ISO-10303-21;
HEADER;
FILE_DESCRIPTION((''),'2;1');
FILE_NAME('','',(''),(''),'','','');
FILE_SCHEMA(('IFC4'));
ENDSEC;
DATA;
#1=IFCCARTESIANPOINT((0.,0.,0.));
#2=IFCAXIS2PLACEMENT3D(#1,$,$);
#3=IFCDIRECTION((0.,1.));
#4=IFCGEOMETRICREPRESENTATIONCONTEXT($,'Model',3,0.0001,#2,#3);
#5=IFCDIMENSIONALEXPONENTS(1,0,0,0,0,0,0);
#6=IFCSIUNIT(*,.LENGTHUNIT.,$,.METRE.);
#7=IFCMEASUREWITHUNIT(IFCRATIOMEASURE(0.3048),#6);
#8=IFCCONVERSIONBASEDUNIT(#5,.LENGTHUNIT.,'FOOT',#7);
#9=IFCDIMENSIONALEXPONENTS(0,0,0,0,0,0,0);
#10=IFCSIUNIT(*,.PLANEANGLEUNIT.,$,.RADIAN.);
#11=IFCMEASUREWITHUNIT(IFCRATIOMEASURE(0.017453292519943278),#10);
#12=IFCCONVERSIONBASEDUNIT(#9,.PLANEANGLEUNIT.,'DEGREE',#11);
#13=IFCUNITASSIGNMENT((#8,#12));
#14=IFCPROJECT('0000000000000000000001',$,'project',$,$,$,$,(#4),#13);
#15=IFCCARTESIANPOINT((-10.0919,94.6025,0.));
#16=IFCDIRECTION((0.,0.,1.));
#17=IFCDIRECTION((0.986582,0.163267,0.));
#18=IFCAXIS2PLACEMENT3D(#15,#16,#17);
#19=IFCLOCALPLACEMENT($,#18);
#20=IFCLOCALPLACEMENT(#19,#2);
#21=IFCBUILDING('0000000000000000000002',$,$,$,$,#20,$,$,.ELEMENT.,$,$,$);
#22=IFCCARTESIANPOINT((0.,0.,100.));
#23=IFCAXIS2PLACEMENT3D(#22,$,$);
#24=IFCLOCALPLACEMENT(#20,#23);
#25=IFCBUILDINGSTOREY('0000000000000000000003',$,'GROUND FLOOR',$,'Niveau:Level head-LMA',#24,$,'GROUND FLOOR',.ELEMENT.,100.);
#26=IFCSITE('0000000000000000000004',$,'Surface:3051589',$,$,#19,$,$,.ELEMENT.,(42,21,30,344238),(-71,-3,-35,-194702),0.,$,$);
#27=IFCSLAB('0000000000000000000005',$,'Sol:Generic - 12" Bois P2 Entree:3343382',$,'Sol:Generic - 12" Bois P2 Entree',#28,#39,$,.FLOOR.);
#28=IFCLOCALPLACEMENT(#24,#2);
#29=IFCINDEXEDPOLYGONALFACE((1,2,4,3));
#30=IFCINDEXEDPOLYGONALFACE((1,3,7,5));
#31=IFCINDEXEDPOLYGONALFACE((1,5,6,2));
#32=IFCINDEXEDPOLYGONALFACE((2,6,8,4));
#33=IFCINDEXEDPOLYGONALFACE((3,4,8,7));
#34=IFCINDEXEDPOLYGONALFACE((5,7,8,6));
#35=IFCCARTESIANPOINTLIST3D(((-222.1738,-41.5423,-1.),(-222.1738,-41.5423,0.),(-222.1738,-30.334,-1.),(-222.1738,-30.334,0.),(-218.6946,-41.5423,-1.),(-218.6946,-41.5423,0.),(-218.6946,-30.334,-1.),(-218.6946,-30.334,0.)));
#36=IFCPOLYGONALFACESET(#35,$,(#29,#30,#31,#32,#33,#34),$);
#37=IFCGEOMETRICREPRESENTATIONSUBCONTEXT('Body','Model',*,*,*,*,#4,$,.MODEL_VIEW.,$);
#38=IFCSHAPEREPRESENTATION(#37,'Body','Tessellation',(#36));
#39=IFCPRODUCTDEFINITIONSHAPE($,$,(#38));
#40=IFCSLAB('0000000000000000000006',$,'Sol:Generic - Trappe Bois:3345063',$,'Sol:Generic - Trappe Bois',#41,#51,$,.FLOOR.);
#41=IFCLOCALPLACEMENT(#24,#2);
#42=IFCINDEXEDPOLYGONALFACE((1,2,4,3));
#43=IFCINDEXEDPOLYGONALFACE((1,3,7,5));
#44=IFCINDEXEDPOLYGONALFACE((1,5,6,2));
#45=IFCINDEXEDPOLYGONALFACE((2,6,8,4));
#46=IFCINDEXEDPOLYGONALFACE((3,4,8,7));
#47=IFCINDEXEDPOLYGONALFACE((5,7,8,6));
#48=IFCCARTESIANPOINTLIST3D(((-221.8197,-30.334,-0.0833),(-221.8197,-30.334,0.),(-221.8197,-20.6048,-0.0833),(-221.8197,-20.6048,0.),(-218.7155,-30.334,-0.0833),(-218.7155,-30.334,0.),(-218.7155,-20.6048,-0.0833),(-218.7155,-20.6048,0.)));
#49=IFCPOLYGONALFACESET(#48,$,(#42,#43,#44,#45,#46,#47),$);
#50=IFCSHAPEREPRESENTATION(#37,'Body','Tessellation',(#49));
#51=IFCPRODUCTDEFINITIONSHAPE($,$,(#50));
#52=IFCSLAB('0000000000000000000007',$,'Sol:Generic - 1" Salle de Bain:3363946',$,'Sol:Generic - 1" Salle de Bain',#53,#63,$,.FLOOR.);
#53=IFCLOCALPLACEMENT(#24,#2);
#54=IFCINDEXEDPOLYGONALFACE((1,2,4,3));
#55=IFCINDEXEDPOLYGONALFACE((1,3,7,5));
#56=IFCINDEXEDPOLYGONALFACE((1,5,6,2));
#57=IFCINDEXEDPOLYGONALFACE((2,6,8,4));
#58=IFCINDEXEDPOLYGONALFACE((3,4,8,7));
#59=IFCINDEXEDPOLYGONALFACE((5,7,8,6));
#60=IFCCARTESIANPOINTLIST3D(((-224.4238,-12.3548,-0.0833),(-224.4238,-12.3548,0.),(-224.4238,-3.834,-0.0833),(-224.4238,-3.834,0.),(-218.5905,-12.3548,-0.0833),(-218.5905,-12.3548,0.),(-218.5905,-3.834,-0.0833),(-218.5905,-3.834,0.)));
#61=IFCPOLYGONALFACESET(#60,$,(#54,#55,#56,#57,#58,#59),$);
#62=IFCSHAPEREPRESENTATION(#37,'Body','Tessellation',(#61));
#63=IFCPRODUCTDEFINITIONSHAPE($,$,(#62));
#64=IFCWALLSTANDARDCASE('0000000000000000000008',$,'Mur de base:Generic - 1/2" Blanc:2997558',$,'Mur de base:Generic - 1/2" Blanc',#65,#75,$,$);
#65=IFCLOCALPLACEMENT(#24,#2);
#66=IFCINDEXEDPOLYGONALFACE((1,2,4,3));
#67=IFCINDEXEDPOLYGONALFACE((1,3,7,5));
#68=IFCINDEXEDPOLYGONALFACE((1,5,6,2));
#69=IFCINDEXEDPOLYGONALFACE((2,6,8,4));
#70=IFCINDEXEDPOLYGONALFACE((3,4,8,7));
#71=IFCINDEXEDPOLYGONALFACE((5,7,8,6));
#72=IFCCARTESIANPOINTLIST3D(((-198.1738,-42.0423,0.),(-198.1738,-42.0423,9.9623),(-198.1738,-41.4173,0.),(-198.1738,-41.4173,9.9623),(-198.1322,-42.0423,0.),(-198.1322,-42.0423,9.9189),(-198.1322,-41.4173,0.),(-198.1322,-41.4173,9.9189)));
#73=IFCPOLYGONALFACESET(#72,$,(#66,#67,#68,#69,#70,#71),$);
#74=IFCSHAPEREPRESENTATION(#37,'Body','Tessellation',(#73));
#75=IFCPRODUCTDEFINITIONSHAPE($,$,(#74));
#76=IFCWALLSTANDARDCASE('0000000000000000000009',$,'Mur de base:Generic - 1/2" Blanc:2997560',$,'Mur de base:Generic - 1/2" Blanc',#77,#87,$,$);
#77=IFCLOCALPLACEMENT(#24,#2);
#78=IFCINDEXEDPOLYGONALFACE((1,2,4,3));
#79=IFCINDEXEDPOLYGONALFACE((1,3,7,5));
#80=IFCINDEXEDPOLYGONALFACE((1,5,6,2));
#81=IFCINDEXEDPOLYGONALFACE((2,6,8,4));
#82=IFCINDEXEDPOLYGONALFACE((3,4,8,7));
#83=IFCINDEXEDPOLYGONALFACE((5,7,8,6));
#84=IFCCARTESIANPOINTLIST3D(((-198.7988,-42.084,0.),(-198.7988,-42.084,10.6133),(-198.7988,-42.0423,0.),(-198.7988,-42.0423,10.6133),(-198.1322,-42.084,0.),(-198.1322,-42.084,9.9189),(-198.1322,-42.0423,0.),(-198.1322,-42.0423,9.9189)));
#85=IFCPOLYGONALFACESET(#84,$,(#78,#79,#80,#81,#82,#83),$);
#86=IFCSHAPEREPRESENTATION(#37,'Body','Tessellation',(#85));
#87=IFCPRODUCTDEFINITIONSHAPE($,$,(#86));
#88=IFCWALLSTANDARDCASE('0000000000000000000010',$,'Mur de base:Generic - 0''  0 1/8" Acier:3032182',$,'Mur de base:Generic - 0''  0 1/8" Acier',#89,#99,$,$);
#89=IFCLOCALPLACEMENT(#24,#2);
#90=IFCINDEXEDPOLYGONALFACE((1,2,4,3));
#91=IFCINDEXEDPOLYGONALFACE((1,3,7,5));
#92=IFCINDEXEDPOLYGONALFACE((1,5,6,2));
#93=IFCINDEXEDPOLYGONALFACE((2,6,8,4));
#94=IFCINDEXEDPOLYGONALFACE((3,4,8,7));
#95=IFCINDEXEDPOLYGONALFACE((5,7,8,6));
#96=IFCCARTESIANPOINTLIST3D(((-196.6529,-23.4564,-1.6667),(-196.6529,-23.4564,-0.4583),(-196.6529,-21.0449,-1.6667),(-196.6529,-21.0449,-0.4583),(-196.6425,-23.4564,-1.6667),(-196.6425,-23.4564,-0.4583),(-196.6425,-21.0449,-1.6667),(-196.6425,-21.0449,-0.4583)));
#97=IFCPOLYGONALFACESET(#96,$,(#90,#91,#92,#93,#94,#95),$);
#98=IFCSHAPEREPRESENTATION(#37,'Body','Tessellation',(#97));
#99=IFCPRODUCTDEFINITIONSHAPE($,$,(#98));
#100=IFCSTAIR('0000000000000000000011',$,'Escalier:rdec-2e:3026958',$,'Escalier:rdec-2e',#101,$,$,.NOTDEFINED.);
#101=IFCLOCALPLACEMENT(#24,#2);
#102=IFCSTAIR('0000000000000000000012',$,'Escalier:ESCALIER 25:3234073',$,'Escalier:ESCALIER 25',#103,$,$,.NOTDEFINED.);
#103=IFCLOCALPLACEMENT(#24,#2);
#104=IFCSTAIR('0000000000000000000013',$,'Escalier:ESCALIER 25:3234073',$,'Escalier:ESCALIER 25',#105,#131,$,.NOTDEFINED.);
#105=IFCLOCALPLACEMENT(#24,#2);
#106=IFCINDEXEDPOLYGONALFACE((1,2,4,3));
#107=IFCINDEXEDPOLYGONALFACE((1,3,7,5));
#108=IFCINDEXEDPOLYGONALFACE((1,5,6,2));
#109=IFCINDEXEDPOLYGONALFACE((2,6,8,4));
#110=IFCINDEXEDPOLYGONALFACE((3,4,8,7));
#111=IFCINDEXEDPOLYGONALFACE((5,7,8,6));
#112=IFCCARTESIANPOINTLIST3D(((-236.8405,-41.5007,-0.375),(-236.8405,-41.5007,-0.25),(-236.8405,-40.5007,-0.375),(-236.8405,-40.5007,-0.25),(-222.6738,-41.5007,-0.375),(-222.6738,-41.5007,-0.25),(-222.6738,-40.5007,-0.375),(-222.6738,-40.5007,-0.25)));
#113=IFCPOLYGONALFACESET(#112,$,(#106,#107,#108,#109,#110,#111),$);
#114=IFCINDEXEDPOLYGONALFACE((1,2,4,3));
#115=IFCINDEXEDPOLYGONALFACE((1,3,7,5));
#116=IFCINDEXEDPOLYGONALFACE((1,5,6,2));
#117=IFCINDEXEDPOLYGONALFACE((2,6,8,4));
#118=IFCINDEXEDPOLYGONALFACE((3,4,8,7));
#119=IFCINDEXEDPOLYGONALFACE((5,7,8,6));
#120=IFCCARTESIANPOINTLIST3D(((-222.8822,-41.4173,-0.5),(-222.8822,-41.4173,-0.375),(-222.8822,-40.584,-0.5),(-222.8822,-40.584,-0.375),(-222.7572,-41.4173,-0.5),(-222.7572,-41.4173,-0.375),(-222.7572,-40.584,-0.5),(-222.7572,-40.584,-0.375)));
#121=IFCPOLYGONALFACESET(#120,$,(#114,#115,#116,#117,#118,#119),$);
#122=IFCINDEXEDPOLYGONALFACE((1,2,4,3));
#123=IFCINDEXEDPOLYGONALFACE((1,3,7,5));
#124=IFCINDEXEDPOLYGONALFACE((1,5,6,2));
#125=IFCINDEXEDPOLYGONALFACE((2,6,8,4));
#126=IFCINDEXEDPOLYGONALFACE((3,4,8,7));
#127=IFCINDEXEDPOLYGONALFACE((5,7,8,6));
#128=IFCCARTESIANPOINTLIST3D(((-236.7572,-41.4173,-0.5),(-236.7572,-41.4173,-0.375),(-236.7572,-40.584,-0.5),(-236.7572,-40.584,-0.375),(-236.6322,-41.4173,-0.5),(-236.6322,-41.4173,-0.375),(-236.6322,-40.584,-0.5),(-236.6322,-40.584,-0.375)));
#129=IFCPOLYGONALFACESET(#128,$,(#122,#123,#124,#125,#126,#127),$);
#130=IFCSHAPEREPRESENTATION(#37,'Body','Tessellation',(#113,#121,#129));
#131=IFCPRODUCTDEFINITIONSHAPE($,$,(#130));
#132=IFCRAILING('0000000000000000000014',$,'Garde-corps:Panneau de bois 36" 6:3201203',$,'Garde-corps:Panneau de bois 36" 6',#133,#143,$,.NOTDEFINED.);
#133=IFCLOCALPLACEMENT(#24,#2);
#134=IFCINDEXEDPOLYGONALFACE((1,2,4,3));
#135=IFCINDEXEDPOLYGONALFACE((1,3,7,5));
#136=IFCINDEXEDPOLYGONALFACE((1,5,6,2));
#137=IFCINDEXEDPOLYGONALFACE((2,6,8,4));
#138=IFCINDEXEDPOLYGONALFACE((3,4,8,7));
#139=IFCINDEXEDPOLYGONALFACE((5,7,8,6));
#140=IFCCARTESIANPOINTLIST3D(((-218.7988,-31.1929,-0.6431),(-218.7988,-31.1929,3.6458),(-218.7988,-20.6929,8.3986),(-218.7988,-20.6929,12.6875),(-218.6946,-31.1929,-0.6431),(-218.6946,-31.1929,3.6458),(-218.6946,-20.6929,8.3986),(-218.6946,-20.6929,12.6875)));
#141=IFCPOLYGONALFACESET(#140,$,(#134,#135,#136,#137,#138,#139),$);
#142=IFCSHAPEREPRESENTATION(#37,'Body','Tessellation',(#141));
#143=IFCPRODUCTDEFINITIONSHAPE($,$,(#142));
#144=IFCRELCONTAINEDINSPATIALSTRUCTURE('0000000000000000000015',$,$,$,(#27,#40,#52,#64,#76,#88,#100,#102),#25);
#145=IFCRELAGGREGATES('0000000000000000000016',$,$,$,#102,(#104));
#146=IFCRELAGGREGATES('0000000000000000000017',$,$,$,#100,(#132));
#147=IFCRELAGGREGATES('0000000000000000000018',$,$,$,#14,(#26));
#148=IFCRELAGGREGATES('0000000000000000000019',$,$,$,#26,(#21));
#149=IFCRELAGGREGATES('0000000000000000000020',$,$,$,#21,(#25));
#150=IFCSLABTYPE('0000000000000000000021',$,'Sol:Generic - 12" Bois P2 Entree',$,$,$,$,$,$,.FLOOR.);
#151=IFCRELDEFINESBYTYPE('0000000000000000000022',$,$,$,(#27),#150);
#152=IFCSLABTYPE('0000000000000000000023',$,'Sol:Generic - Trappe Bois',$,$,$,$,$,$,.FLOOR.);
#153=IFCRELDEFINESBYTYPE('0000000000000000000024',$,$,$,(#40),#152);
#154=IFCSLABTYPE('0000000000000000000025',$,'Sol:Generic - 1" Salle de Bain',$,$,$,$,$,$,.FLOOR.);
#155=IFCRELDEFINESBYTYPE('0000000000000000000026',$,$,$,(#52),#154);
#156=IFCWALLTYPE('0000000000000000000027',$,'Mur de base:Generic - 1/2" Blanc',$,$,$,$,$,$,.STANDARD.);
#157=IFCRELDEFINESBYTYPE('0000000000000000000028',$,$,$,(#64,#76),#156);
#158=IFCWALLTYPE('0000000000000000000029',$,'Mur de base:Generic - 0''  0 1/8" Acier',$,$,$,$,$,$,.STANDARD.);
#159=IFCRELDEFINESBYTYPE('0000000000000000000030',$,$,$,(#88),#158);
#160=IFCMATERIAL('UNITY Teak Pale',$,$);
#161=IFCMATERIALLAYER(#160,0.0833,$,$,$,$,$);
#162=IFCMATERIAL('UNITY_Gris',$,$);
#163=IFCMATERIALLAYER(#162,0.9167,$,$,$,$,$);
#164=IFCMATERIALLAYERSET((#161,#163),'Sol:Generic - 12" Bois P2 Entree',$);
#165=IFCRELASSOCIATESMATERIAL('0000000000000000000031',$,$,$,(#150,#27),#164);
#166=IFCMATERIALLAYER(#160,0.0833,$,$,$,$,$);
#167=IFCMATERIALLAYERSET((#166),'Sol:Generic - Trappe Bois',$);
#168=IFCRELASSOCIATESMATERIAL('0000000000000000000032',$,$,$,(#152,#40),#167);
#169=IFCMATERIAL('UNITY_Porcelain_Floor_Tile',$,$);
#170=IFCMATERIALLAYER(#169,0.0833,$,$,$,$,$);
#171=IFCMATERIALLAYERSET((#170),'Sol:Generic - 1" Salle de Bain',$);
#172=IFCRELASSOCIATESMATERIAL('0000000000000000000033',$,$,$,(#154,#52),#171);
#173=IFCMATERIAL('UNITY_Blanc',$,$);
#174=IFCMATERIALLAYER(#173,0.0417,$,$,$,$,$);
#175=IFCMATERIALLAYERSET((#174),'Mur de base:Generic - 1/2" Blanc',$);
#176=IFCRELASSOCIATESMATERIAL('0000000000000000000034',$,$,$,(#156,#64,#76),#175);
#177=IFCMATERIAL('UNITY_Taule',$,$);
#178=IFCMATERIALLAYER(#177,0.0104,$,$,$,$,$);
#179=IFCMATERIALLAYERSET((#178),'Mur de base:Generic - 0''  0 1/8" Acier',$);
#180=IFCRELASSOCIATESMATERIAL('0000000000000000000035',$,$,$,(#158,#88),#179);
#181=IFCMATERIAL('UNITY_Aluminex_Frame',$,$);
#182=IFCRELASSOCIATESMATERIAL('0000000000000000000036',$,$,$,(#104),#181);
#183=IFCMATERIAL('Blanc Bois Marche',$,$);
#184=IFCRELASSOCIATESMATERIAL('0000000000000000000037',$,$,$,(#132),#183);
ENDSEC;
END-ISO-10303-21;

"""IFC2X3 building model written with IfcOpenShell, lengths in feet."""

from ifc_helpers import new_model, entity, si_unit, converted_unit, direction, frame, frame_2d, origin, place, context, subcontext, project, spatial, polyline, rectangle, outline, extrude, clip, bounded_halfspace, material, layer, layer_set, layer_usage, type_object, element, aggregate, save


model = new_model("IFC2X3")

# Units and contexts
model_context = context("Model", 3, precision=0.0001, world=origin(), true_north=direction((0.0, 1.0)))
body_context = subcontext(model_context, "Body", "Model", "MODEL_VIEW")
ifc_project = project(units=[converted_unit("LENGTHUNIT", "FOOT", entity("IfcRatioMeasure", 0.3048), si_unit("LENGTHUNIT", "METRE"), dimensions=[1, 0, 0, 0, 0, 0, 0]), converted_unit("PLANEANGLEUNIT", "DEGREE", entity("IfcRatioMeasure", 0.017453292519943278), si_unit("PLANEANGLEUNIT", "RADIAN"), dimensions=[0, 0, 0, 0, 0, 0, 0])], contexts=[model_context])

# Site, building, storey
site_placement = place(None, frame((-10.0919, 94.6025, 0.0), z_axis=(0.0, 0.0, 1.0), x_axis=(0.986582, 0.163267, 0.0)))
site = spatial("IfcSite", under=ifc_project, at=site_placement, Name="Surface:3051589", CompositionType="ELEMENT", RefLatitude=(42, 21, 30, 344238), RefLongitude=(-71, -3, -35, -194702), RefElevation=0.0)
building_placement = place(site_placement, origin())
building = spatial("IfcBuilding", under=site, at=building_placement, CompositionType="ELEMENT")
storey_placement = place(building_placement, frame((0.0, 0.0, 100.0)))
storey = spatial("IfcBuildingStorey", under=building, at=storey_placement, Name="GROUND FLOOR", ObjectType="Niveau:Level head-LMA", LongName="GROUND FLOOR", CompositionType="ELEMENT", Elevation=100.0)

# Slabs
ifc_material_1 = material(Name="UNITY_Gris")
ifc_material_2 = material(Name="UNITY Teak Pale")
ifc_layer_1 = layer(ifc_material_2, 0.0833)
ifc_layer_2 = layer(ifc_material_1, 0.9167)
ifc_layer_set_1 = layer_set([ifc_layer_1, ifc_layer_2], Name="Sol:Generic - 12\" Bois P2 Entree")
ifc_layer_usage_1 = layer_usage(ifc_layer_set_1, "AXIS3", "POSITIVE", 0.0)
slab_type_1 = type_object("IfcSlabType", Name="Sol:Generic - 12\" Bois P2 Entree", PredefinedType="FLOOR", material=ifc_layer_set_1)
slab_1_placement = place(storey_placement, origin())
element("IfcSlab", 1, at=slab_1_placement, inside=storey, type_object=slab_type_1, material=ifc_layer_usage_1, Name="Sol:Generic - 12\" Bois P2 Entree:3343382", ObjectType="Sol:Generic - 12\" Bois P2 Entree", PredefinedType="FLOOR", context=body_context, shape_type="SweptSolid", body=[
    extrude(rectangle(XDim=11.2083, YDim=3.4792, at=frame_2d((0.0, 0.0), x_axis=(1.0, 0.0))), frame((-220.4342, -35.9382, 0.0), z_axis=(0.0, 0.0, -1.0), x_axis=(0.0, 1.0, 0.0)), (0.0, 0.0, 1.0), 1.0),
])
ifc_layer_3 = layer(ifc_material_2, 0.0833)
ifc_layer_set_2 = layer_set([ifc_layer_3], Name="Sol:Generic - Trappe Bois")
ifc_layer_usage_2 = layer_usage(ifc_layer_set_2, "AXIS3", "POSITIVE", 0.0)
slab_type_2 = type_object("IfcSlabType", Name="Sol:Generic - Trappe Bois", PredefinedType="FLOOR", material=ifc_layer_set_2)
slab_2_placement = place(storey_placement, origin())
element("IfcSlab", 2, at=slab_2_placement, inside=storey, type_object=slab_type_2, material=ifc_layer_usage_2, Name="Sol:Generic - Trappe Bois:3345063", ObjectType="Sol:Generic - Trappe Bois", PredefinedType="FLOOR", context=body_context, shape_type="SweptSolid", body=[
    extrude(rectangle(XDim=9.7292, YDim=3.1042, at=frame_2d((0.0, 0.0), x_axis=(1.0, 0.0))), frame((-220.2676, -25.4694, 0.0), z_axis=(0.0, 0.0, -1.0), x_axis=(0.0, 1.0, 0.0)), (0.0, 0.0, 1.0), 0.0833),
])
ifc_material_3 = material(Name="UNITY_Porcelain_Floor_Tile")
ifc_layer_4 = layer(ifc_material_3, 0.0833)
ifc_layer_set_3 = layer_set([ifc_layer_4], Name="Sol:Generic - 1\" Salle de Bain")
ifc_layer_usage_3 = layer_usage(ifc_layer_set_3, "AXIS3", "POSITIVE", 0.0)
slab_type_3 = type_object("IfcSlabType", Name="Sol:Generic - 1\" Salle de Bain", PredefinedType="FLOOR", material=ifc_layer_set_3)
slab_3_placement = place(storey_placement, origin())
element("IfcSlab", 3, at=slab_3_placement, inside=storey, type_object=slab_type_3, material=ifc_layer_usage_3, Name="Sol:Generic - 1\" Salle de Bain:3363946", ObjectType="Sol:Generic - 1\" Salle de Bain", PredefinedType="FLOOR", context=body_context, shape_type="SweptSolid", body=[
    extrude(rectangle(XDim=8.5208, YDim=5.8333, at=frame_2d((0.0, 0.0), x_axis=(1.0, 0.0))), frame((-221.5072, -8.0944, 0.0), z_axis=(0.0, 0.0, -1.0), x_axis=(0.0, 1.0, 0.0)), (0.0, 0.0, 1.0), 0.0833),
])

# Walls
ifc_material_4 = material(Name="UNITY_Blanc")
ifc_layer_5 = layer(ifc_material_4, 0.0417)
ifc_layer_set_4 = layer_set([ifc_layer_5], Name="Mur de base:Generic - 1/2\" Blanc")
ifc_layer_usage_4 = layer_usage(ifc_layer_set_4, "AXIS2", "NEGATIVE", 0.0208)
wall_type_1 = type_object("IfcWallType", Name="Mur de base:Generic - 1/2\" Blanc", PredefinedType="STANDARD", material=ifc_layer_set_4)
wall_1_placement = place(storey_placement, frame((-198.153, -41.4173, 0.0), z_axis=(0.0, 0.0, 1.0), x_axis=(0.0, -1.0, 0.0)))
element("IfcWallStandardCase", 4, at=wall_1_placement, inside=storey, type_object=wall_type_1, material=ifc_layer_usage_4, Name="Mur de base:Generic - 1/2\" Blanc:2997558", ObjectType="Mur de base:Generic - 1/2\" Blanc", context=body_context, shape_type="Clipping", body=[
    clip(extrude(rectangle(XDim=0.625, YDim=0.0417, at=frame_2d((0.3125, 0.0), x_axis=(-1.0, 0.0))), origin(), (0.0, 0.0, 1.0), 9.9623), bounded_halfspace(frame((0.0, -0.0208, 9.9623), z_axis=(0.0, 0.721387, 0.692532), x_axis=(-1.0, 0.0, 0.0)), False, frame((0.0, -0.0208, 9.9623)), polyline([(0.0, 0.0), (0.625, 0.0), (0.625, 0.0417), (0.0, 0.0417), (0.0, 0.0)]))),
])
ifc_layer_usage_5 = layer_usage(ifc_layer_set_4, "AXIS2", "NEGATIVE", 0.0208)
wall_2_placement = place(storey_placement, frame((-198.1322, -42.0632, 0.0), z_axis=(0.0, 0.0, 1.0), x_axis=(-1.0, 0.0, 0.0)))
element("IfcWallStandardCase", 5, at=wall_2_placement, inside=storey, type_object=wall_type_1, material=ifc_layer_usage_5, Name="Mur de base:Generic - 1/2\" Blanc:2997560", ObjectType="Mur de base:Generic - 1/2\" Blanc", context=body_context, shape_type="Clipping", body=[
    clip(extrude(rectangle(XDim=0.6667, YDim=0.0417, at=frame_2d((0.3333, 0.0), x_axis=(-1.0, 0.0))), origin(), (0.0, 0.0, 1.0), 10.6133), bounded_halfspace(frame((0.0, -0.0208, 9.9189), z_axis=(-0.721387, 0.0, 0.692532), x_axis=(0.0, -1.0, 0.0)), False, frame((0.0, -0.0208, 9.9189)), polyline([(0.0, 0.0), (0.0417, 0.0), (0.6667, 0.0), (0.6667, 0.0417), (0.0, 0.0417), (0.0, 0.0)]))),
])
ifc_material_5 = material(Name="UNITY_Taule")
ifc_layer_6 = layer(ifc_material_5, 0.0104)
ifc_layer_set_5 = layer_set([ifc_layer_6], Name="Mur de base:Generic - 0'  0 1/8\" Acier")
ifc_layer_usage_6 = layer_usage(ifc_layer_set_5, "AXIS2", "NEGATIVE", 0.0052)
wall_type_2 = type_object("IfcWallType", Name="Mur de base:Generic - 0'  0 1/8\" Acier", PredefinedType="STANDARD", material=ifc_layer_set_5)
wall_3_placement = place(storey_placement, frame((-196.6477, -23.4564, -1.6667), z_axis=(0.0, 0.0, 1.0), x_axis=(0.0, 1.0, 0.0)))
element("IfcWallStandardCase", 6, at=wall_3_placement, inside=storey, type_object=wall_type_2, material=ifc_layer_usage_6, Name="Mur de base:Generic - 0'  0 1/8\" Acier:3032182", ObjectType="Mur de base:Generic - 0'  0 1/8\" Acier", context=body_context, shape_type="SweptSolid", body=[
    extrude(rectangle(XDim=2.4115, YDim=0.0104, at=frame_2d((1.2057, 0.0), x_axis=(-1.0, 0.0))), origin(), (0.0, 0.0, 1.0), 1.2083),
])

# Stairs
stair_1_placement = place(storey_placement, origin())
stair_1 = element("IfcStair", 7, at=stair_1_placement, inside=storey, Name="Escalier:rdec-2e:3026958", ObjectType="Escalier:rdec-2e", ShapeType="NOTDEFINED")
stair_2_placement = place(storey_placement, origin())
stair_2 = element("IfcStair", 8, at=stair_2_placement, inside=storey, Name="Escalier:ESCALIER 25:3234073", ObjectType="Escalier:ESCALIER 25", ShapeType="NOTDEFINED")
ifc_material_6 = material(Name="UNITY_Aluminex_Frame")
stair_3_placement = place(stair_2_placement, origin())
stair_3 = element("IfcStair", 9, at=stair_3_placement, material=ifc_material_6, Name="Escalier:ESCALIER 25:3234073", ObjectType="Escalier:ESCALIER 25", ShapeType="NOTDEFINED", context=body_context, shape_type="SweptSolid", body=[
    extrude(rectangle(XDim=1.0, YDim=14.1667, at=frame_2d((0.0, 0.0), x_axis=(1.0, 0.0))), frame((-229.7572, -41.0007, -0.375), z_axis=(0.0, 0.0, 1.0), x_axis=(0.0, -1.0, 0.0)), (0.0, 0.0, 1.0), 0.125),
    extrude(rectangle(XDim=0.8333, YDim=0.125, at=frame_2d((0.0, 0.0), x_axis=(1.0, 0.0))), frame((-222.8197, -41.0007, -0.5), z_axis=(0.0, 0.0, 1.0), x_axis=(0.0, -1.0, 0.0)), (0.0, 0.0, 1.0), 0.125),
    extrude(rectangle(XDim=0.8333, YDim=0.125, at=frame_2d((0.0, 0.0), x_axis=(1.0, 0.0))), frame((-236.6947, -41.0007, -0.5), z_axis=(0.0, 0.0, 1.0), x_axis=(0.0, -1.0, 0.0)), (0.0, 0.0, 1.0), 0.125),
])
aggregate(stair_2, [stair_3])

# Railing
ifc_material_7 = material(Name="Blanc Bois Marche")
railing_placement = place(stair_1_placement, frame((0.0, 0.0, 9.3333)))
railing = element("IfcRailing", 10, at=railing_placement, material=ifc_material_7, Name="Garde-corps:Panneau de bois 36\" 6:3201203", ObjectType="Garde-corps:Panneau de bois 36\" 6", PredefinedType="NOTDEFINED", context=body_context, shape_type="SweptSolid", body=[
    extrude(outline(polyline([(-8.3275, -1.625), (5.5289, -1.625), (8.3275, 1.625), (-5.5289, 1.625), (-8.3275, -1.625)])), frame((-218.7988, -25.9429, -3.3111), z_axis=(1.0, 0.0, 0.0), x_axis=(0.0, -0.757769, -0.652523)), (0.0, 0.0, 1.0), 0.1042),
])
aggregate(stair_1, [railing])

save(model, "model.ifc")
